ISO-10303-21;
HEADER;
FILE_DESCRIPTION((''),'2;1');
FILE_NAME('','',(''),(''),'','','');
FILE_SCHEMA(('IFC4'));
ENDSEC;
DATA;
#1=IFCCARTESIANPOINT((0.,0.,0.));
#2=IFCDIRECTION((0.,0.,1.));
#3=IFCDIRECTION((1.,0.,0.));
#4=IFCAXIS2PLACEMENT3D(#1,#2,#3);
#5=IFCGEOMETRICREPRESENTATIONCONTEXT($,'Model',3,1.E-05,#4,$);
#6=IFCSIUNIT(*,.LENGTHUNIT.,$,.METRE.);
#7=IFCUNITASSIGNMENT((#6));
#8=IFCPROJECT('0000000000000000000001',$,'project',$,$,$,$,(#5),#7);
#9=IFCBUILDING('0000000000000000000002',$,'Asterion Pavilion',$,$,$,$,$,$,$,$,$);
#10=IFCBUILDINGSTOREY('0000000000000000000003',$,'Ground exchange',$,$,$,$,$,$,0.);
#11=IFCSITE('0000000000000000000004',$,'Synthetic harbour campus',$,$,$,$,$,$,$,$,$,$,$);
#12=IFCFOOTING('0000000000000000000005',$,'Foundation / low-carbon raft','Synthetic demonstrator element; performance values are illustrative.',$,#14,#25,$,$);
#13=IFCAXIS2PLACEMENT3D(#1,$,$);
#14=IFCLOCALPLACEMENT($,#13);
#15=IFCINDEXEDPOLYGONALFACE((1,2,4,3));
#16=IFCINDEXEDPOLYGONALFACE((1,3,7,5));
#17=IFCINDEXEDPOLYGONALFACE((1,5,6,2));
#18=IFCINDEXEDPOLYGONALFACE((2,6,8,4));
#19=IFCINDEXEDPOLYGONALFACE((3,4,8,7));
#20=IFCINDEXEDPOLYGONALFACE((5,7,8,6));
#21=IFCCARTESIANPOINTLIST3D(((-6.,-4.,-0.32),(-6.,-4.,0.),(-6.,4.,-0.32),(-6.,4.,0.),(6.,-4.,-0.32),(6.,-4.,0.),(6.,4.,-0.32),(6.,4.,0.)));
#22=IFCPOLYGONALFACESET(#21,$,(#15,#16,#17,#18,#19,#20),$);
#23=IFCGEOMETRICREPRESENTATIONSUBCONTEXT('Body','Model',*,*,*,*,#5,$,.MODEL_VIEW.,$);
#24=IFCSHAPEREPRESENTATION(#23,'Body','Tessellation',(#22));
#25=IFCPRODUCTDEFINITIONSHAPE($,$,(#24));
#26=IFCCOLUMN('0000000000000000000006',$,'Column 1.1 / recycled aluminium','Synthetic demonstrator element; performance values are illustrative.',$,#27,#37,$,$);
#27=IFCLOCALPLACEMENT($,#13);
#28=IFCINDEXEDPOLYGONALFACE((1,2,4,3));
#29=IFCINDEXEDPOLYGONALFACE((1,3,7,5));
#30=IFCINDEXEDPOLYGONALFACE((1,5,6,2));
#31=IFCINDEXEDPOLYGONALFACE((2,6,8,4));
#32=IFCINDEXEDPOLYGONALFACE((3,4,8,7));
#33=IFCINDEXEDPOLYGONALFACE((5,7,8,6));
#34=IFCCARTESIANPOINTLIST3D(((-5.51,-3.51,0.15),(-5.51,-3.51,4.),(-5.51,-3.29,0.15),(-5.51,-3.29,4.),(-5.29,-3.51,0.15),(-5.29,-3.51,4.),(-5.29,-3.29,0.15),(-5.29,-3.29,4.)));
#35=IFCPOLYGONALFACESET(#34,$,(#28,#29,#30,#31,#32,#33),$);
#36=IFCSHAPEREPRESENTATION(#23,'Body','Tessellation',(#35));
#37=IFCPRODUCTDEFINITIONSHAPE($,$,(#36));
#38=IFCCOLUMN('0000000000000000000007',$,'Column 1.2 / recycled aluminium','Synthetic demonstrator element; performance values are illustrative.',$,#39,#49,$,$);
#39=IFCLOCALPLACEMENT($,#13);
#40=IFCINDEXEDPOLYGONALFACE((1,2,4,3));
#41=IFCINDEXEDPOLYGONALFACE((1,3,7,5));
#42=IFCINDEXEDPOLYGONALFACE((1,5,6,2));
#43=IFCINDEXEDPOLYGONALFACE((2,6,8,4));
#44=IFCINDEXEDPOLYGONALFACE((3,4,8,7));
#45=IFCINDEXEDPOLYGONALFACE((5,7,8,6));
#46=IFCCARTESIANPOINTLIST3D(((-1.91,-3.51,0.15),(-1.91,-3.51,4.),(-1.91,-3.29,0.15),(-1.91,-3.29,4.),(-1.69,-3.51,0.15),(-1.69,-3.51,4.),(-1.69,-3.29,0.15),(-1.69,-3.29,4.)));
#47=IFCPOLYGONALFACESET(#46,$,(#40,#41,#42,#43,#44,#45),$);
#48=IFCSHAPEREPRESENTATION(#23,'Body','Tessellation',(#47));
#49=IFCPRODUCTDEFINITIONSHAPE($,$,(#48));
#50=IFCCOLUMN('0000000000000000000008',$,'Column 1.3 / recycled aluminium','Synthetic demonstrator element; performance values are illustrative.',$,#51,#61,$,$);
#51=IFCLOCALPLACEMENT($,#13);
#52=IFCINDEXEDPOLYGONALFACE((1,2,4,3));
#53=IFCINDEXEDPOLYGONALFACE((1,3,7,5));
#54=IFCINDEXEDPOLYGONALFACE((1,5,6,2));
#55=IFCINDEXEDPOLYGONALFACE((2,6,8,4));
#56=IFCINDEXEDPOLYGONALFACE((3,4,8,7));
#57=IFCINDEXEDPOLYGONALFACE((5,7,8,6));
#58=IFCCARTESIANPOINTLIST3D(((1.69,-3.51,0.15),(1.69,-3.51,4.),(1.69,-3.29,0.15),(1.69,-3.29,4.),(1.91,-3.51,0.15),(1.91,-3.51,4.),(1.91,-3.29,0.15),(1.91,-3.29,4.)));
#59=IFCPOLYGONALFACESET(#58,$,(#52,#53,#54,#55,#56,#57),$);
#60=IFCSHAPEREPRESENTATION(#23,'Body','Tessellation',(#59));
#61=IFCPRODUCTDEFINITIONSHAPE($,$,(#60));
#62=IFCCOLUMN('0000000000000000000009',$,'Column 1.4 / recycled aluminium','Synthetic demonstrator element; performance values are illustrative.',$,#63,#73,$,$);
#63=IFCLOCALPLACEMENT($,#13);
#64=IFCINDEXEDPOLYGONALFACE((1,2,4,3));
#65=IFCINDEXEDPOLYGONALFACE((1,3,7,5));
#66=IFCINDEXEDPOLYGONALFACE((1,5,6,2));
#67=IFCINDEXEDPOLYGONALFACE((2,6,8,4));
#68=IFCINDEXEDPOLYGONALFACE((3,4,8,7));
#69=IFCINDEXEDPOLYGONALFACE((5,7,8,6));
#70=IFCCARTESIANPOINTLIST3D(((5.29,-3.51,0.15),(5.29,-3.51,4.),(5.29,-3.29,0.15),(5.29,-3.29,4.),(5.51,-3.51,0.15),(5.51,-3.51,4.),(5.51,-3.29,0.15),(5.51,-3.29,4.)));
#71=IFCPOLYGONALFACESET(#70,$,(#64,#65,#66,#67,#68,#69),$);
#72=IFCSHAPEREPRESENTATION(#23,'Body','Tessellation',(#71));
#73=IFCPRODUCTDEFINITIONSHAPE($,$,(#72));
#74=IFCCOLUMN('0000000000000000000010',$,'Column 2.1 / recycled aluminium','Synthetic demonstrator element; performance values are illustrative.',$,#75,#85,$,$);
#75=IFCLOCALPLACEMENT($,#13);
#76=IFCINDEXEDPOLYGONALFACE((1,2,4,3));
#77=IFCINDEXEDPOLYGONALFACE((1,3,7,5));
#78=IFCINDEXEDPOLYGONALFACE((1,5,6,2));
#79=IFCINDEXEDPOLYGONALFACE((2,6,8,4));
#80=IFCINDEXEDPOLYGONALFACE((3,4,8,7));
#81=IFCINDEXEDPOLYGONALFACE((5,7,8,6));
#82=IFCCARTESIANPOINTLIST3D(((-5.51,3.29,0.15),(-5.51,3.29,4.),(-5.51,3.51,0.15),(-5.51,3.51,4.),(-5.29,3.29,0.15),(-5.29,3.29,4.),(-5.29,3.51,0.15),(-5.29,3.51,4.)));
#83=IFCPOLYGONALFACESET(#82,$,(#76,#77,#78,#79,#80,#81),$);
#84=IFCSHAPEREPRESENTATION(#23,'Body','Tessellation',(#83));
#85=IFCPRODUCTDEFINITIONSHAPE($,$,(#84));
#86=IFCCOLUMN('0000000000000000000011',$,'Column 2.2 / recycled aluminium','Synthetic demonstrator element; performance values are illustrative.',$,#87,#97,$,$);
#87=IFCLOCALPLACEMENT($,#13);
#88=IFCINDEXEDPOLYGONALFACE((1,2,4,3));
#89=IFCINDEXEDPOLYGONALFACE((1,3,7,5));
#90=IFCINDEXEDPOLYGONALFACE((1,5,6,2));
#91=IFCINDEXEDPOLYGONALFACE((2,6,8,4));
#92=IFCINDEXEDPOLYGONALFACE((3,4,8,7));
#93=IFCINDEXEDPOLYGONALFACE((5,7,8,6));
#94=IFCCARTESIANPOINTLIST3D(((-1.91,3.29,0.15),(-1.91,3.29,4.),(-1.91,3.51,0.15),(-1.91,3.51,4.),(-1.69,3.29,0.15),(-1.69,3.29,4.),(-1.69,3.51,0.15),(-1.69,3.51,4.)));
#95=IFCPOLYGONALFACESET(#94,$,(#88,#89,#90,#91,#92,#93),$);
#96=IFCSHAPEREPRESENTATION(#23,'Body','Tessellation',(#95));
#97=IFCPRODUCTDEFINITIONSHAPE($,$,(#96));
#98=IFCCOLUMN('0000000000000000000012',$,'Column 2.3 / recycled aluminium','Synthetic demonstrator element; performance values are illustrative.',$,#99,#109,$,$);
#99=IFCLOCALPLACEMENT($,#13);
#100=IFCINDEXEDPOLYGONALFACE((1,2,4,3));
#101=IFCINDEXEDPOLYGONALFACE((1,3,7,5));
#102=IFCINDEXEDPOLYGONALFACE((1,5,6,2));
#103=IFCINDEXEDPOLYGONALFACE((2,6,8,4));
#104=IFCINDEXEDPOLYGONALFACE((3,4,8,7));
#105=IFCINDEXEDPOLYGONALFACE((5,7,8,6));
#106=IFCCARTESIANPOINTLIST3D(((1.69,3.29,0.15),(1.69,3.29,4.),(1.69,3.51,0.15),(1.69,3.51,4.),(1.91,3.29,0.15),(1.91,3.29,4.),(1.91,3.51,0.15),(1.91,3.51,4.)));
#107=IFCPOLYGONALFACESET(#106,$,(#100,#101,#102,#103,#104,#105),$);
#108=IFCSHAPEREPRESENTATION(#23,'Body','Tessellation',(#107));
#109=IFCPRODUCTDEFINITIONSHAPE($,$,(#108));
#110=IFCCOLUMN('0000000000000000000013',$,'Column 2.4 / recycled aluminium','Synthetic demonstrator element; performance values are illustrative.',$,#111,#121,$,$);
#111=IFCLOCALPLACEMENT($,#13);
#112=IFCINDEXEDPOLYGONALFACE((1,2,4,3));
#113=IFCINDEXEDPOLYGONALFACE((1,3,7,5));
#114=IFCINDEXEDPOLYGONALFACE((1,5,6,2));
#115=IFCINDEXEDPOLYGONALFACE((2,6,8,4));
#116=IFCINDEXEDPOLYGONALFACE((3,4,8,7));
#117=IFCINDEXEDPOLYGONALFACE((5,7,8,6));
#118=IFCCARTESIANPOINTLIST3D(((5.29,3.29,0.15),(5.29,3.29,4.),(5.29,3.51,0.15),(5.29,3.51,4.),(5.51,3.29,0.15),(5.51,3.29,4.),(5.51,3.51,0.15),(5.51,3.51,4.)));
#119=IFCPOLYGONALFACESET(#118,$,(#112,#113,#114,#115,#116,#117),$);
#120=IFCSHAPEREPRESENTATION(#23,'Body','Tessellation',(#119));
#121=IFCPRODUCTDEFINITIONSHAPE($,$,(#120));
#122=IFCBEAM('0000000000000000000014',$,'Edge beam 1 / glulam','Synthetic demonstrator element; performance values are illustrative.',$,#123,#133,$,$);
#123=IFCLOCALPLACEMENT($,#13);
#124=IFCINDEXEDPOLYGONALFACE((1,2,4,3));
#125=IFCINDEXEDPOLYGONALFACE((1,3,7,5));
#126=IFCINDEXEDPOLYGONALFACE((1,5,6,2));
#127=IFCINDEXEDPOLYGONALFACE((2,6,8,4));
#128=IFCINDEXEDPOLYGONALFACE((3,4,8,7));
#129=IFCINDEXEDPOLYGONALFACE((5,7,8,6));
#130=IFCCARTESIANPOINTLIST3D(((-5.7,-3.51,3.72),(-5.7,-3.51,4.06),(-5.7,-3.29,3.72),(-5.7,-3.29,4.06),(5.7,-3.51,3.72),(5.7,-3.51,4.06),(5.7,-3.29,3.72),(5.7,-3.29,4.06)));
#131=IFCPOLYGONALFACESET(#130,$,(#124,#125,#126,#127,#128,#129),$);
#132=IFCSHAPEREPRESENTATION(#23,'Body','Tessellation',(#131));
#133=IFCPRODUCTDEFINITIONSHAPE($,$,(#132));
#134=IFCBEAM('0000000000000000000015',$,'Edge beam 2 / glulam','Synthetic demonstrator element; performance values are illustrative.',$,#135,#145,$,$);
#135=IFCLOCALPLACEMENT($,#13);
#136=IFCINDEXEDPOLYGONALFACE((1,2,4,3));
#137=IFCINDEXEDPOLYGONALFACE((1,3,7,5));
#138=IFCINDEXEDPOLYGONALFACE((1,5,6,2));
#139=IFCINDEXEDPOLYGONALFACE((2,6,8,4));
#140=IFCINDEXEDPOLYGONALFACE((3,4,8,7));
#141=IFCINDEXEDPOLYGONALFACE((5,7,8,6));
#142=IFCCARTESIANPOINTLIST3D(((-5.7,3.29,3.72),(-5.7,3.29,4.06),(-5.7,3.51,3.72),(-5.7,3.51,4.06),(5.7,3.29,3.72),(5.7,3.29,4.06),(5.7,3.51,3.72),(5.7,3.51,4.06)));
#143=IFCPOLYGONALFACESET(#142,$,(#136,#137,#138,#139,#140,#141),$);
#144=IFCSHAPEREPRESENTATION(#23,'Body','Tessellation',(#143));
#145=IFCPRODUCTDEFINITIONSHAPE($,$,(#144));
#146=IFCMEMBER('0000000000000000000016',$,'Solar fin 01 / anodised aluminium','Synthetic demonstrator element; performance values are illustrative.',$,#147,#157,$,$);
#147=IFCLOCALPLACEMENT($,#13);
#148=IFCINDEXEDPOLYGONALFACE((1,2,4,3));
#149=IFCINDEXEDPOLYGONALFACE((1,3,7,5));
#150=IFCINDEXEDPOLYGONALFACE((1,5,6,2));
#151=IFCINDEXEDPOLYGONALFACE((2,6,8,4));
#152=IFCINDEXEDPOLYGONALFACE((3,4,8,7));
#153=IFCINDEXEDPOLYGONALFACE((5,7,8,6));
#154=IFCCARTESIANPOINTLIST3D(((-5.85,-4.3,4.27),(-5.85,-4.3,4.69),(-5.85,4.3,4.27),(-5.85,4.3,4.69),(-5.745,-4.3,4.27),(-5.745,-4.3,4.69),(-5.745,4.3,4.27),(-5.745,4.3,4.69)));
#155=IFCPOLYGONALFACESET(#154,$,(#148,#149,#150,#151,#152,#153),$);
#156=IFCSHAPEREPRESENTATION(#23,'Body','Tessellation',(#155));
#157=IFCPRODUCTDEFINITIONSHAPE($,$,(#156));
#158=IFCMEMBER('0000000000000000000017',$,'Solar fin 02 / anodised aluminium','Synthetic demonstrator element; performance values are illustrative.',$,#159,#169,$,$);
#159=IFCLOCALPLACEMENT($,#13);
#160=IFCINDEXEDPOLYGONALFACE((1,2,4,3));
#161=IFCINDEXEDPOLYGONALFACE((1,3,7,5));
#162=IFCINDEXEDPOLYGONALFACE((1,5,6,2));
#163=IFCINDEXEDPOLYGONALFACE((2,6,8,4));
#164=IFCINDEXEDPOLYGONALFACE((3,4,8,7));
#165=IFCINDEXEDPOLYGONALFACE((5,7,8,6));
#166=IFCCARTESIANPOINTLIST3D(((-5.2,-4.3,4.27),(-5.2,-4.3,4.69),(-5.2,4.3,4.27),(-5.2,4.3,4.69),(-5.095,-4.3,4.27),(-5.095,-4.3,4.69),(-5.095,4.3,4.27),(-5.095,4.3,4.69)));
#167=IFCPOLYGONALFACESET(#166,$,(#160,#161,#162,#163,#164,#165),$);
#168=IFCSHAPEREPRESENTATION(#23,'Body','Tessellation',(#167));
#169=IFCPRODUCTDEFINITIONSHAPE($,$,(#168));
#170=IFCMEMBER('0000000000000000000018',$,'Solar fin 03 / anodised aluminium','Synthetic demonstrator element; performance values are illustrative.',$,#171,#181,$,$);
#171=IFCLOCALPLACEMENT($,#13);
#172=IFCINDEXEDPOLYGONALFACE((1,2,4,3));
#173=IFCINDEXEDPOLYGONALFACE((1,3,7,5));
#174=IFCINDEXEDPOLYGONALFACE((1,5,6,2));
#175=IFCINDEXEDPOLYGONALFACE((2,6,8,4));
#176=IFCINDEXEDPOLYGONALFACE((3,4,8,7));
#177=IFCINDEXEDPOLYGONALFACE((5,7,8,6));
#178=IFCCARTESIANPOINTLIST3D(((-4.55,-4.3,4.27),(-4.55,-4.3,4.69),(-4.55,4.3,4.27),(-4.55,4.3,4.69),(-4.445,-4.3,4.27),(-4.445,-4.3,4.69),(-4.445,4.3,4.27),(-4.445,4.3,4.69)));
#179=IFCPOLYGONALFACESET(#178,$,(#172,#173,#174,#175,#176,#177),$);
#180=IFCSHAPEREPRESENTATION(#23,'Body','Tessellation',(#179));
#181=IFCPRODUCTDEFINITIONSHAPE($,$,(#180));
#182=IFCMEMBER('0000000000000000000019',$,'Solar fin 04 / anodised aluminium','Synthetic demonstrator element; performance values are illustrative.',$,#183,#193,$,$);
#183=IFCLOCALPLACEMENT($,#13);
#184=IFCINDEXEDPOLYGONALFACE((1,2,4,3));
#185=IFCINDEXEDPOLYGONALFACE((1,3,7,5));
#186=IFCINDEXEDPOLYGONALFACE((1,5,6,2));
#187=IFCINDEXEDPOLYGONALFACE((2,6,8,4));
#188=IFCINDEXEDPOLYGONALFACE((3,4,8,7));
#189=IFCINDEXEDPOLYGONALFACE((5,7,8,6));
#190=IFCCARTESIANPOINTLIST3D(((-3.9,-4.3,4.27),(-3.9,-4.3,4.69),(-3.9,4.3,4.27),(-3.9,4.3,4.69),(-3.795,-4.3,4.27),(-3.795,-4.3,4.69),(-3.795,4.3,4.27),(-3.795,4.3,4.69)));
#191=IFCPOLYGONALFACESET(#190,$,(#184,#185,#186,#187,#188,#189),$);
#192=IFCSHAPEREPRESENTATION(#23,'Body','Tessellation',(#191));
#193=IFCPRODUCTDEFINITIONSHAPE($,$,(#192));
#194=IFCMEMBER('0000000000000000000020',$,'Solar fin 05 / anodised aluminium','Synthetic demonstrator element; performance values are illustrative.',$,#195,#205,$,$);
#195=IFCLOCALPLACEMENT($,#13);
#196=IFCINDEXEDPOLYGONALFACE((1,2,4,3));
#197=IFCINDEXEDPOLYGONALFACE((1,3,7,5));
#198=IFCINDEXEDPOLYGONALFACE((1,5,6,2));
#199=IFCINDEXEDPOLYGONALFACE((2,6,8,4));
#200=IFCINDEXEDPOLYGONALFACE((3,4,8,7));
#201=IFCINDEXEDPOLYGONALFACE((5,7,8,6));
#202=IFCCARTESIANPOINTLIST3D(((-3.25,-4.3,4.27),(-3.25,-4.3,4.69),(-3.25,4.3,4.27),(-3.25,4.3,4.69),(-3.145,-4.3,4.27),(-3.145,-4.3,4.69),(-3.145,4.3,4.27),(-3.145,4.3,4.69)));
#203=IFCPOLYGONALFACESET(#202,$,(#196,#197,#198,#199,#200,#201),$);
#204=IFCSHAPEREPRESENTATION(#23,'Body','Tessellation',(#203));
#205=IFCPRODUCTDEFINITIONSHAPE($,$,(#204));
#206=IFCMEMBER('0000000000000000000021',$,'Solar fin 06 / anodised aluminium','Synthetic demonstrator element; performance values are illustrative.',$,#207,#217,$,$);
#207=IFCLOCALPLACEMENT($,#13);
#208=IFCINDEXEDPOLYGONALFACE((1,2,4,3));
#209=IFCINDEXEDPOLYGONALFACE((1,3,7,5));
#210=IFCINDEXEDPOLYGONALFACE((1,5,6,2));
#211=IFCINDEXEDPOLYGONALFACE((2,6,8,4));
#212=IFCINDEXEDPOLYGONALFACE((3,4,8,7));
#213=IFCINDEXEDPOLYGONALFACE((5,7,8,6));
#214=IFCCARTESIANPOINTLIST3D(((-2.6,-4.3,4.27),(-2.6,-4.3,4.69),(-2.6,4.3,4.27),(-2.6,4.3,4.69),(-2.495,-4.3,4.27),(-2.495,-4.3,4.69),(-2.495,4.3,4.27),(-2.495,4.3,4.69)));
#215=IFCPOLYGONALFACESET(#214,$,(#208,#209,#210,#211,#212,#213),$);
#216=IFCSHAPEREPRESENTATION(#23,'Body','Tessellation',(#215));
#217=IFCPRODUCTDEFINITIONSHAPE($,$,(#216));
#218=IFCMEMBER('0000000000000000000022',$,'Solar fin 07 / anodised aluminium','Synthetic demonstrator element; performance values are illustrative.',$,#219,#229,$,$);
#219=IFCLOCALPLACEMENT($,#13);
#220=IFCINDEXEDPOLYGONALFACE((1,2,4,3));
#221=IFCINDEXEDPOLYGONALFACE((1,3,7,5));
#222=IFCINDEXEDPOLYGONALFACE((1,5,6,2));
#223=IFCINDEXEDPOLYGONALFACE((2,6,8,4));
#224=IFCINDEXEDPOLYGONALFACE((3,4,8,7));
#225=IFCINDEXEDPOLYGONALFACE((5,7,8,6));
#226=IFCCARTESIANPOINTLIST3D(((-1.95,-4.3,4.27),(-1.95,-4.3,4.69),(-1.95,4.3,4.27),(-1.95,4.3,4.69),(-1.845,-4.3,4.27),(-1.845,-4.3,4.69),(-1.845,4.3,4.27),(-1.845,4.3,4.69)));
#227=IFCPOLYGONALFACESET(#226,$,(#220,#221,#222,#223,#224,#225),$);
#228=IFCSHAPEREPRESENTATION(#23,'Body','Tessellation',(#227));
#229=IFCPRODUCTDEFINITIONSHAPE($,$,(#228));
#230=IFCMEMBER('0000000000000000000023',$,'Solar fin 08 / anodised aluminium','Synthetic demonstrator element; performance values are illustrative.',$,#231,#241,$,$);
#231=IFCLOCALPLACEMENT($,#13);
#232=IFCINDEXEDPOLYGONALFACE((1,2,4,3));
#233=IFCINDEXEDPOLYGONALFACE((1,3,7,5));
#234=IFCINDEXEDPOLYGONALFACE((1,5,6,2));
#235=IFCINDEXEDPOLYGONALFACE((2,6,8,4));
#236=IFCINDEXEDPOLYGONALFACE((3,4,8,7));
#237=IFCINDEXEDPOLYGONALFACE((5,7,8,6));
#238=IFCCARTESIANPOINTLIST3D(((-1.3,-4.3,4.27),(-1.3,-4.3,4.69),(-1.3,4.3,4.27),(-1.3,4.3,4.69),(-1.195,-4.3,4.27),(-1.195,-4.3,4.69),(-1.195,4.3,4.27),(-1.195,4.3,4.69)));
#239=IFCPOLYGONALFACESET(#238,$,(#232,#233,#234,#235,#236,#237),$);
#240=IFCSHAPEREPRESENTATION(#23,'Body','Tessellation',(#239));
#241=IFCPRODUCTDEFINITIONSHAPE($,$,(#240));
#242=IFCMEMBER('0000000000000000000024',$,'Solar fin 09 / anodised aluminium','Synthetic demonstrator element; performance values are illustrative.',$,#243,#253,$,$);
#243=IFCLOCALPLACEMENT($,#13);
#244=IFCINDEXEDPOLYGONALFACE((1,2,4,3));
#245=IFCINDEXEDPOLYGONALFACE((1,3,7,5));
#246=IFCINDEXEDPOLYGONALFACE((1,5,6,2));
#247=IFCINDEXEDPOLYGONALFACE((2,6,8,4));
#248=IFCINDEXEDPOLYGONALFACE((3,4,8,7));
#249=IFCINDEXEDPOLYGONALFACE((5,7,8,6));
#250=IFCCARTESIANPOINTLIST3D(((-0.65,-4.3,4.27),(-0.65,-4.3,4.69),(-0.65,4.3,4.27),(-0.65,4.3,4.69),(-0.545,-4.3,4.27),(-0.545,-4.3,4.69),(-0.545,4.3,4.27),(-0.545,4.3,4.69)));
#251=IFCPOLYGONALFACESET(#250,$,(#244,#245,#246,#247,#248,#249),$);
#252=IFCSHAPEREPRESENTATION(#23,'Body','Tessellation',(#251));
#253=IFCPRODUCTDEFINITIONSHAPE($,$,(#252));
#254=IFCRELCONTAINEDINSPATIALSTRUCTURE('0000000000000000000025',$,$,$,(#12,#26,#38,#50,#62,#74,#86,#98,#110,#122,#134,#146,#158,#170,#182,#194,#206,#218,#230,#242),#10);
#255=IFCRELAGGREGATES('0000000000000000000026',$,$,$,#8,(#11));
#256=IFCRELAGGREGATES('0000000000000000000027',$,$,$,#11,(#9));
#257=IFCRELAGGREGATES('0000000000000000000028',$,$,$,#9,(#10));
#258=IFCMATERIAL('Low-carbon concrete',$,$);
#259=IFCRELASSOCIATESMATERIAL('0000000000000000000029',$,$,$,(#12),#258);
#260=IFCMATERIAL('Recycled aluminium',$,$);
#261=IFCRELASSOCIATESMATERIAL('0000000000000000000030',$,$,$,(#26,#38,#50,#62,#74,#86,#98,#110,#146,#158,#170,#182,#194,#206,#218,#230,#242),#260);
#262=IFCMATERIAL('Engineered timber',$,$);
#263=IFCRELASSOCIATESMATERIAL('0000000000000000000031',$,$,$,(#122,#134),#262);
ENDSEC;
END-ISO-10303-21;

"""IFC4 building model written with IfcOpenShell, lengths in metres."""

from ifc_helpers import new_model, si_unit, frame, origin_with_axes, place, context, subcontext, project, spatial, indexed_curve, outline, extrude, material, element, save


model = new_model("IFC4")

# Units and contexts
model_context = context("Model", 3, precision=1e-05, world=origin_with_axes())
body_context = subcontext(model_context, "Body", "Model", "MODEL_VIEW")
ifc_project = project(units=[si_unit("LENGTHUNIT", "METRE")], contexts=[model_context])

# Site, building, storey
site = spatial("IfcSite", under=ifc_project, Name="Synthetic harbour campus")
building = spatial("IfcBuilding", under=site, Name="Asterion Pavilion")
storey = spatial("IfcBuildingStorey", under=building, Name="Ground exchange", Elevation=0.0)

# Footing
ifc_material_1 = material(Name="Low-carbon concrete")
footing_placement = place(None, frame((-6.0, -4.0, -0.32), z_axis=(0.0, 0.0, 1.0), x_axis=(1.0, 0.0, 0.0)))
element("IfcFooting", 1, at=footing_placement, inside=storey, material=ifc_material_1, Name="Foundation / low-carbon raft", Description="Synthetic demonstrator element; performance values are illustrative.", context=body_context, shape_type="SweptSolid", body=[
    extrude(outline(indexed_curve([(0.0, 0.0), (0.0, 8.0), (12.0, 8.0), (12.0, 0.0), (0.0, 0.0)], self_intersect=False)), origin_with_axes(), (0.0, 0.0, 1.0), 0.32),
])

# Columns
ifc_material_2 = material(Name="Recycled aluminium")
for number, where, z_axis, x_axis, name in (
    (2, (-5.51, -3.51, 0.15), (0.0, 0.0, 1.0), (1.0, 0.0, 0.0), "Column 1.1 / recycled aluminium"),
    (3, (-1.91, -3.51, 0.15), (0.0, 0.0, 1.0), (1.0, 0.0, 0.0), "Column 1.2 / recycled aluminium"),
    (4, (1.69, -3.51, 0.15), (0.0, 0.0, 1.0), (1.0, 0.0, 0.0), "Column 1.3 / recycled aluminium"),
    (5, (5.29, -3.51, 0.15), (0.0, 0.0, 1.0), (1.0, 0.0, 0.0), "Column 1.4 / recycled aluminium"),
    (6, (-5.51, 3.29, 0.15), (0.0, 0.0, 1.0), (1.0, 0.0, 0.0), "Column 2.1 / recycled aluminium"),
    (7, (-1.91, 3.29, 0.15), (0.0, 0.0, 1.0), (1.0, 0.0, 0.0), "Column 2.2 / recycled aluminium"),
    (8, (1.69, 3.29, 0.15), (0.0, 0.0, 1.0), (1.0, 0.0, 0.0), "Column 2.3 / recycled aluminium"),
    (9, (5.29, 3.29, 0.15), (0.0, 0.0, 1.0), (1.0, 0.0, 0.0), "Column 2.4 / recycled aluminium"),
):
    element("IfcColumn", number, at=place(None, frame(where, z_axis=z_axis, x_axis=x_axis)), inside=storey, material=ifc_material_2, Name=name, Description="Synthetic demonstrator element; performance values are illustrative.", context=body_context, shape_type="SweptSolid", body=[
        extrude(outline(indexed_curve([(0.0, 0.0), (0.0, 0.22), (0.22, 0.22), (0.22, 0.0), (0.0, 0.0)], self_intersect=False)), origin_with_axes(), (0.0, 0.0, 1.0), 3.85),
    ])

# Beams
ifc_material_3 = material(Name="Engineered timber")
for number, where, z_axis, x_axis, name in (
    (10, (-5.7, -3.51, 3.72), (0.0, 0.0, 1.0), (1.0, 0.0, 0.0), "Edge beam 1 / glulam"),
    (11, (-5.7, 3.29, 3.72), (0.0, 0.0, 1.0), (1.0, 0.0, 0.0), "Edge beam 2 / glulam"),
):
    element("IfcBeam", number, at=place(None, frame(where, z_axis=z_axis, x_axis=x_axis)), inside=storey, material=ifc_material_3, Name=name, Description="Synthetic demonstrator element; performance values are illustrative.", context=body_context, shape_type="SweptSolid", body=[
        extrude(outline(indexed_curve([(0.0, 0.0), (0.0, 0.22), (11.4, 0.22), (11.4, 0.0), (0.0, 0.0)], self_intersect=False)), origin_with_axes(), (0.0, 0.0, 1.0), 0.34),
    ])

# Members
for number, where, z_axis, x_axis, name in (
    (12, (-5.85, -4.3, 4.27), (0.0, 0.0, 1.0), (1.0, 0.0, 0.0), "Solar fin 01 / anodised aluminium"),
    (13, (-5.2, -4.3, 4.27), (0.0, 0.0, 1.0), (1.0, 0.0, 0.0), "Solar fin 02 / anodised aluminium"),
    (14, (-4.55, -4.3, 4.27), (0.0, 0.0, 1.0), (1.0, 0.0, 0.0), "Solar fin 03 / anodised aluminium"),
    (15, (-3.9, -4.3, 4.27), (0.0, 0.0, 1.0), (1.0, 0.0, 0.0), "Solar fin 04 / anodised aluminium"),
    (16, (-3.25, -4.3, 4.27), (0.0, 0.0, 1.0), (1.0, 0.0, 0.0), "Solar fin 05 / anodised aluminium"),
    (17, (-2.6, -4.3, 4.27), (0.0, 0.0, 1.0), (1.0, 0.0, 0.0), "Solar fin 06 / anodised aluminium"),
    (18, (-1.95, -4.3, 4.27), (0.0, 0.0, 1.0), (1.0, 0.0, 0.0), "Solar fin 07 / anodised aluminium"),
    (19, (-1.3, -4.3, 4.27), (0.0, 0.0, 1.0), (1.0, 0.0, 0.0), "Solar fin 08 / anodised aluminium"),
    (20, (-0.65, -4.3, 4.27), (0.0, 0.0, 1.0), (1.0, 0.0, 0.0), "Solar fin 09 / anodised aluminium"),
):
    element("IfcMember", number, at=place(None, frame(where, z_axis=z_axis, x_axis=x_axis)), inside=storey, material=ifc_material_2, Name=name, Description="Synthetic demonstrator element; performance values are illustrative.", context=body_context, shape_type="SweptSolid", body=[
        extrude(outline(indexed_curve([(0.0, 0.0), (0.0, 8.6), (0.105, 8.6), (0.105, 0.0), (0.0, 0.0)], self_intersect=False)), origin_with_axes(), (0.0, 0.0, 1.0), 0.42),
    ])

save(model, "model.ifc")
